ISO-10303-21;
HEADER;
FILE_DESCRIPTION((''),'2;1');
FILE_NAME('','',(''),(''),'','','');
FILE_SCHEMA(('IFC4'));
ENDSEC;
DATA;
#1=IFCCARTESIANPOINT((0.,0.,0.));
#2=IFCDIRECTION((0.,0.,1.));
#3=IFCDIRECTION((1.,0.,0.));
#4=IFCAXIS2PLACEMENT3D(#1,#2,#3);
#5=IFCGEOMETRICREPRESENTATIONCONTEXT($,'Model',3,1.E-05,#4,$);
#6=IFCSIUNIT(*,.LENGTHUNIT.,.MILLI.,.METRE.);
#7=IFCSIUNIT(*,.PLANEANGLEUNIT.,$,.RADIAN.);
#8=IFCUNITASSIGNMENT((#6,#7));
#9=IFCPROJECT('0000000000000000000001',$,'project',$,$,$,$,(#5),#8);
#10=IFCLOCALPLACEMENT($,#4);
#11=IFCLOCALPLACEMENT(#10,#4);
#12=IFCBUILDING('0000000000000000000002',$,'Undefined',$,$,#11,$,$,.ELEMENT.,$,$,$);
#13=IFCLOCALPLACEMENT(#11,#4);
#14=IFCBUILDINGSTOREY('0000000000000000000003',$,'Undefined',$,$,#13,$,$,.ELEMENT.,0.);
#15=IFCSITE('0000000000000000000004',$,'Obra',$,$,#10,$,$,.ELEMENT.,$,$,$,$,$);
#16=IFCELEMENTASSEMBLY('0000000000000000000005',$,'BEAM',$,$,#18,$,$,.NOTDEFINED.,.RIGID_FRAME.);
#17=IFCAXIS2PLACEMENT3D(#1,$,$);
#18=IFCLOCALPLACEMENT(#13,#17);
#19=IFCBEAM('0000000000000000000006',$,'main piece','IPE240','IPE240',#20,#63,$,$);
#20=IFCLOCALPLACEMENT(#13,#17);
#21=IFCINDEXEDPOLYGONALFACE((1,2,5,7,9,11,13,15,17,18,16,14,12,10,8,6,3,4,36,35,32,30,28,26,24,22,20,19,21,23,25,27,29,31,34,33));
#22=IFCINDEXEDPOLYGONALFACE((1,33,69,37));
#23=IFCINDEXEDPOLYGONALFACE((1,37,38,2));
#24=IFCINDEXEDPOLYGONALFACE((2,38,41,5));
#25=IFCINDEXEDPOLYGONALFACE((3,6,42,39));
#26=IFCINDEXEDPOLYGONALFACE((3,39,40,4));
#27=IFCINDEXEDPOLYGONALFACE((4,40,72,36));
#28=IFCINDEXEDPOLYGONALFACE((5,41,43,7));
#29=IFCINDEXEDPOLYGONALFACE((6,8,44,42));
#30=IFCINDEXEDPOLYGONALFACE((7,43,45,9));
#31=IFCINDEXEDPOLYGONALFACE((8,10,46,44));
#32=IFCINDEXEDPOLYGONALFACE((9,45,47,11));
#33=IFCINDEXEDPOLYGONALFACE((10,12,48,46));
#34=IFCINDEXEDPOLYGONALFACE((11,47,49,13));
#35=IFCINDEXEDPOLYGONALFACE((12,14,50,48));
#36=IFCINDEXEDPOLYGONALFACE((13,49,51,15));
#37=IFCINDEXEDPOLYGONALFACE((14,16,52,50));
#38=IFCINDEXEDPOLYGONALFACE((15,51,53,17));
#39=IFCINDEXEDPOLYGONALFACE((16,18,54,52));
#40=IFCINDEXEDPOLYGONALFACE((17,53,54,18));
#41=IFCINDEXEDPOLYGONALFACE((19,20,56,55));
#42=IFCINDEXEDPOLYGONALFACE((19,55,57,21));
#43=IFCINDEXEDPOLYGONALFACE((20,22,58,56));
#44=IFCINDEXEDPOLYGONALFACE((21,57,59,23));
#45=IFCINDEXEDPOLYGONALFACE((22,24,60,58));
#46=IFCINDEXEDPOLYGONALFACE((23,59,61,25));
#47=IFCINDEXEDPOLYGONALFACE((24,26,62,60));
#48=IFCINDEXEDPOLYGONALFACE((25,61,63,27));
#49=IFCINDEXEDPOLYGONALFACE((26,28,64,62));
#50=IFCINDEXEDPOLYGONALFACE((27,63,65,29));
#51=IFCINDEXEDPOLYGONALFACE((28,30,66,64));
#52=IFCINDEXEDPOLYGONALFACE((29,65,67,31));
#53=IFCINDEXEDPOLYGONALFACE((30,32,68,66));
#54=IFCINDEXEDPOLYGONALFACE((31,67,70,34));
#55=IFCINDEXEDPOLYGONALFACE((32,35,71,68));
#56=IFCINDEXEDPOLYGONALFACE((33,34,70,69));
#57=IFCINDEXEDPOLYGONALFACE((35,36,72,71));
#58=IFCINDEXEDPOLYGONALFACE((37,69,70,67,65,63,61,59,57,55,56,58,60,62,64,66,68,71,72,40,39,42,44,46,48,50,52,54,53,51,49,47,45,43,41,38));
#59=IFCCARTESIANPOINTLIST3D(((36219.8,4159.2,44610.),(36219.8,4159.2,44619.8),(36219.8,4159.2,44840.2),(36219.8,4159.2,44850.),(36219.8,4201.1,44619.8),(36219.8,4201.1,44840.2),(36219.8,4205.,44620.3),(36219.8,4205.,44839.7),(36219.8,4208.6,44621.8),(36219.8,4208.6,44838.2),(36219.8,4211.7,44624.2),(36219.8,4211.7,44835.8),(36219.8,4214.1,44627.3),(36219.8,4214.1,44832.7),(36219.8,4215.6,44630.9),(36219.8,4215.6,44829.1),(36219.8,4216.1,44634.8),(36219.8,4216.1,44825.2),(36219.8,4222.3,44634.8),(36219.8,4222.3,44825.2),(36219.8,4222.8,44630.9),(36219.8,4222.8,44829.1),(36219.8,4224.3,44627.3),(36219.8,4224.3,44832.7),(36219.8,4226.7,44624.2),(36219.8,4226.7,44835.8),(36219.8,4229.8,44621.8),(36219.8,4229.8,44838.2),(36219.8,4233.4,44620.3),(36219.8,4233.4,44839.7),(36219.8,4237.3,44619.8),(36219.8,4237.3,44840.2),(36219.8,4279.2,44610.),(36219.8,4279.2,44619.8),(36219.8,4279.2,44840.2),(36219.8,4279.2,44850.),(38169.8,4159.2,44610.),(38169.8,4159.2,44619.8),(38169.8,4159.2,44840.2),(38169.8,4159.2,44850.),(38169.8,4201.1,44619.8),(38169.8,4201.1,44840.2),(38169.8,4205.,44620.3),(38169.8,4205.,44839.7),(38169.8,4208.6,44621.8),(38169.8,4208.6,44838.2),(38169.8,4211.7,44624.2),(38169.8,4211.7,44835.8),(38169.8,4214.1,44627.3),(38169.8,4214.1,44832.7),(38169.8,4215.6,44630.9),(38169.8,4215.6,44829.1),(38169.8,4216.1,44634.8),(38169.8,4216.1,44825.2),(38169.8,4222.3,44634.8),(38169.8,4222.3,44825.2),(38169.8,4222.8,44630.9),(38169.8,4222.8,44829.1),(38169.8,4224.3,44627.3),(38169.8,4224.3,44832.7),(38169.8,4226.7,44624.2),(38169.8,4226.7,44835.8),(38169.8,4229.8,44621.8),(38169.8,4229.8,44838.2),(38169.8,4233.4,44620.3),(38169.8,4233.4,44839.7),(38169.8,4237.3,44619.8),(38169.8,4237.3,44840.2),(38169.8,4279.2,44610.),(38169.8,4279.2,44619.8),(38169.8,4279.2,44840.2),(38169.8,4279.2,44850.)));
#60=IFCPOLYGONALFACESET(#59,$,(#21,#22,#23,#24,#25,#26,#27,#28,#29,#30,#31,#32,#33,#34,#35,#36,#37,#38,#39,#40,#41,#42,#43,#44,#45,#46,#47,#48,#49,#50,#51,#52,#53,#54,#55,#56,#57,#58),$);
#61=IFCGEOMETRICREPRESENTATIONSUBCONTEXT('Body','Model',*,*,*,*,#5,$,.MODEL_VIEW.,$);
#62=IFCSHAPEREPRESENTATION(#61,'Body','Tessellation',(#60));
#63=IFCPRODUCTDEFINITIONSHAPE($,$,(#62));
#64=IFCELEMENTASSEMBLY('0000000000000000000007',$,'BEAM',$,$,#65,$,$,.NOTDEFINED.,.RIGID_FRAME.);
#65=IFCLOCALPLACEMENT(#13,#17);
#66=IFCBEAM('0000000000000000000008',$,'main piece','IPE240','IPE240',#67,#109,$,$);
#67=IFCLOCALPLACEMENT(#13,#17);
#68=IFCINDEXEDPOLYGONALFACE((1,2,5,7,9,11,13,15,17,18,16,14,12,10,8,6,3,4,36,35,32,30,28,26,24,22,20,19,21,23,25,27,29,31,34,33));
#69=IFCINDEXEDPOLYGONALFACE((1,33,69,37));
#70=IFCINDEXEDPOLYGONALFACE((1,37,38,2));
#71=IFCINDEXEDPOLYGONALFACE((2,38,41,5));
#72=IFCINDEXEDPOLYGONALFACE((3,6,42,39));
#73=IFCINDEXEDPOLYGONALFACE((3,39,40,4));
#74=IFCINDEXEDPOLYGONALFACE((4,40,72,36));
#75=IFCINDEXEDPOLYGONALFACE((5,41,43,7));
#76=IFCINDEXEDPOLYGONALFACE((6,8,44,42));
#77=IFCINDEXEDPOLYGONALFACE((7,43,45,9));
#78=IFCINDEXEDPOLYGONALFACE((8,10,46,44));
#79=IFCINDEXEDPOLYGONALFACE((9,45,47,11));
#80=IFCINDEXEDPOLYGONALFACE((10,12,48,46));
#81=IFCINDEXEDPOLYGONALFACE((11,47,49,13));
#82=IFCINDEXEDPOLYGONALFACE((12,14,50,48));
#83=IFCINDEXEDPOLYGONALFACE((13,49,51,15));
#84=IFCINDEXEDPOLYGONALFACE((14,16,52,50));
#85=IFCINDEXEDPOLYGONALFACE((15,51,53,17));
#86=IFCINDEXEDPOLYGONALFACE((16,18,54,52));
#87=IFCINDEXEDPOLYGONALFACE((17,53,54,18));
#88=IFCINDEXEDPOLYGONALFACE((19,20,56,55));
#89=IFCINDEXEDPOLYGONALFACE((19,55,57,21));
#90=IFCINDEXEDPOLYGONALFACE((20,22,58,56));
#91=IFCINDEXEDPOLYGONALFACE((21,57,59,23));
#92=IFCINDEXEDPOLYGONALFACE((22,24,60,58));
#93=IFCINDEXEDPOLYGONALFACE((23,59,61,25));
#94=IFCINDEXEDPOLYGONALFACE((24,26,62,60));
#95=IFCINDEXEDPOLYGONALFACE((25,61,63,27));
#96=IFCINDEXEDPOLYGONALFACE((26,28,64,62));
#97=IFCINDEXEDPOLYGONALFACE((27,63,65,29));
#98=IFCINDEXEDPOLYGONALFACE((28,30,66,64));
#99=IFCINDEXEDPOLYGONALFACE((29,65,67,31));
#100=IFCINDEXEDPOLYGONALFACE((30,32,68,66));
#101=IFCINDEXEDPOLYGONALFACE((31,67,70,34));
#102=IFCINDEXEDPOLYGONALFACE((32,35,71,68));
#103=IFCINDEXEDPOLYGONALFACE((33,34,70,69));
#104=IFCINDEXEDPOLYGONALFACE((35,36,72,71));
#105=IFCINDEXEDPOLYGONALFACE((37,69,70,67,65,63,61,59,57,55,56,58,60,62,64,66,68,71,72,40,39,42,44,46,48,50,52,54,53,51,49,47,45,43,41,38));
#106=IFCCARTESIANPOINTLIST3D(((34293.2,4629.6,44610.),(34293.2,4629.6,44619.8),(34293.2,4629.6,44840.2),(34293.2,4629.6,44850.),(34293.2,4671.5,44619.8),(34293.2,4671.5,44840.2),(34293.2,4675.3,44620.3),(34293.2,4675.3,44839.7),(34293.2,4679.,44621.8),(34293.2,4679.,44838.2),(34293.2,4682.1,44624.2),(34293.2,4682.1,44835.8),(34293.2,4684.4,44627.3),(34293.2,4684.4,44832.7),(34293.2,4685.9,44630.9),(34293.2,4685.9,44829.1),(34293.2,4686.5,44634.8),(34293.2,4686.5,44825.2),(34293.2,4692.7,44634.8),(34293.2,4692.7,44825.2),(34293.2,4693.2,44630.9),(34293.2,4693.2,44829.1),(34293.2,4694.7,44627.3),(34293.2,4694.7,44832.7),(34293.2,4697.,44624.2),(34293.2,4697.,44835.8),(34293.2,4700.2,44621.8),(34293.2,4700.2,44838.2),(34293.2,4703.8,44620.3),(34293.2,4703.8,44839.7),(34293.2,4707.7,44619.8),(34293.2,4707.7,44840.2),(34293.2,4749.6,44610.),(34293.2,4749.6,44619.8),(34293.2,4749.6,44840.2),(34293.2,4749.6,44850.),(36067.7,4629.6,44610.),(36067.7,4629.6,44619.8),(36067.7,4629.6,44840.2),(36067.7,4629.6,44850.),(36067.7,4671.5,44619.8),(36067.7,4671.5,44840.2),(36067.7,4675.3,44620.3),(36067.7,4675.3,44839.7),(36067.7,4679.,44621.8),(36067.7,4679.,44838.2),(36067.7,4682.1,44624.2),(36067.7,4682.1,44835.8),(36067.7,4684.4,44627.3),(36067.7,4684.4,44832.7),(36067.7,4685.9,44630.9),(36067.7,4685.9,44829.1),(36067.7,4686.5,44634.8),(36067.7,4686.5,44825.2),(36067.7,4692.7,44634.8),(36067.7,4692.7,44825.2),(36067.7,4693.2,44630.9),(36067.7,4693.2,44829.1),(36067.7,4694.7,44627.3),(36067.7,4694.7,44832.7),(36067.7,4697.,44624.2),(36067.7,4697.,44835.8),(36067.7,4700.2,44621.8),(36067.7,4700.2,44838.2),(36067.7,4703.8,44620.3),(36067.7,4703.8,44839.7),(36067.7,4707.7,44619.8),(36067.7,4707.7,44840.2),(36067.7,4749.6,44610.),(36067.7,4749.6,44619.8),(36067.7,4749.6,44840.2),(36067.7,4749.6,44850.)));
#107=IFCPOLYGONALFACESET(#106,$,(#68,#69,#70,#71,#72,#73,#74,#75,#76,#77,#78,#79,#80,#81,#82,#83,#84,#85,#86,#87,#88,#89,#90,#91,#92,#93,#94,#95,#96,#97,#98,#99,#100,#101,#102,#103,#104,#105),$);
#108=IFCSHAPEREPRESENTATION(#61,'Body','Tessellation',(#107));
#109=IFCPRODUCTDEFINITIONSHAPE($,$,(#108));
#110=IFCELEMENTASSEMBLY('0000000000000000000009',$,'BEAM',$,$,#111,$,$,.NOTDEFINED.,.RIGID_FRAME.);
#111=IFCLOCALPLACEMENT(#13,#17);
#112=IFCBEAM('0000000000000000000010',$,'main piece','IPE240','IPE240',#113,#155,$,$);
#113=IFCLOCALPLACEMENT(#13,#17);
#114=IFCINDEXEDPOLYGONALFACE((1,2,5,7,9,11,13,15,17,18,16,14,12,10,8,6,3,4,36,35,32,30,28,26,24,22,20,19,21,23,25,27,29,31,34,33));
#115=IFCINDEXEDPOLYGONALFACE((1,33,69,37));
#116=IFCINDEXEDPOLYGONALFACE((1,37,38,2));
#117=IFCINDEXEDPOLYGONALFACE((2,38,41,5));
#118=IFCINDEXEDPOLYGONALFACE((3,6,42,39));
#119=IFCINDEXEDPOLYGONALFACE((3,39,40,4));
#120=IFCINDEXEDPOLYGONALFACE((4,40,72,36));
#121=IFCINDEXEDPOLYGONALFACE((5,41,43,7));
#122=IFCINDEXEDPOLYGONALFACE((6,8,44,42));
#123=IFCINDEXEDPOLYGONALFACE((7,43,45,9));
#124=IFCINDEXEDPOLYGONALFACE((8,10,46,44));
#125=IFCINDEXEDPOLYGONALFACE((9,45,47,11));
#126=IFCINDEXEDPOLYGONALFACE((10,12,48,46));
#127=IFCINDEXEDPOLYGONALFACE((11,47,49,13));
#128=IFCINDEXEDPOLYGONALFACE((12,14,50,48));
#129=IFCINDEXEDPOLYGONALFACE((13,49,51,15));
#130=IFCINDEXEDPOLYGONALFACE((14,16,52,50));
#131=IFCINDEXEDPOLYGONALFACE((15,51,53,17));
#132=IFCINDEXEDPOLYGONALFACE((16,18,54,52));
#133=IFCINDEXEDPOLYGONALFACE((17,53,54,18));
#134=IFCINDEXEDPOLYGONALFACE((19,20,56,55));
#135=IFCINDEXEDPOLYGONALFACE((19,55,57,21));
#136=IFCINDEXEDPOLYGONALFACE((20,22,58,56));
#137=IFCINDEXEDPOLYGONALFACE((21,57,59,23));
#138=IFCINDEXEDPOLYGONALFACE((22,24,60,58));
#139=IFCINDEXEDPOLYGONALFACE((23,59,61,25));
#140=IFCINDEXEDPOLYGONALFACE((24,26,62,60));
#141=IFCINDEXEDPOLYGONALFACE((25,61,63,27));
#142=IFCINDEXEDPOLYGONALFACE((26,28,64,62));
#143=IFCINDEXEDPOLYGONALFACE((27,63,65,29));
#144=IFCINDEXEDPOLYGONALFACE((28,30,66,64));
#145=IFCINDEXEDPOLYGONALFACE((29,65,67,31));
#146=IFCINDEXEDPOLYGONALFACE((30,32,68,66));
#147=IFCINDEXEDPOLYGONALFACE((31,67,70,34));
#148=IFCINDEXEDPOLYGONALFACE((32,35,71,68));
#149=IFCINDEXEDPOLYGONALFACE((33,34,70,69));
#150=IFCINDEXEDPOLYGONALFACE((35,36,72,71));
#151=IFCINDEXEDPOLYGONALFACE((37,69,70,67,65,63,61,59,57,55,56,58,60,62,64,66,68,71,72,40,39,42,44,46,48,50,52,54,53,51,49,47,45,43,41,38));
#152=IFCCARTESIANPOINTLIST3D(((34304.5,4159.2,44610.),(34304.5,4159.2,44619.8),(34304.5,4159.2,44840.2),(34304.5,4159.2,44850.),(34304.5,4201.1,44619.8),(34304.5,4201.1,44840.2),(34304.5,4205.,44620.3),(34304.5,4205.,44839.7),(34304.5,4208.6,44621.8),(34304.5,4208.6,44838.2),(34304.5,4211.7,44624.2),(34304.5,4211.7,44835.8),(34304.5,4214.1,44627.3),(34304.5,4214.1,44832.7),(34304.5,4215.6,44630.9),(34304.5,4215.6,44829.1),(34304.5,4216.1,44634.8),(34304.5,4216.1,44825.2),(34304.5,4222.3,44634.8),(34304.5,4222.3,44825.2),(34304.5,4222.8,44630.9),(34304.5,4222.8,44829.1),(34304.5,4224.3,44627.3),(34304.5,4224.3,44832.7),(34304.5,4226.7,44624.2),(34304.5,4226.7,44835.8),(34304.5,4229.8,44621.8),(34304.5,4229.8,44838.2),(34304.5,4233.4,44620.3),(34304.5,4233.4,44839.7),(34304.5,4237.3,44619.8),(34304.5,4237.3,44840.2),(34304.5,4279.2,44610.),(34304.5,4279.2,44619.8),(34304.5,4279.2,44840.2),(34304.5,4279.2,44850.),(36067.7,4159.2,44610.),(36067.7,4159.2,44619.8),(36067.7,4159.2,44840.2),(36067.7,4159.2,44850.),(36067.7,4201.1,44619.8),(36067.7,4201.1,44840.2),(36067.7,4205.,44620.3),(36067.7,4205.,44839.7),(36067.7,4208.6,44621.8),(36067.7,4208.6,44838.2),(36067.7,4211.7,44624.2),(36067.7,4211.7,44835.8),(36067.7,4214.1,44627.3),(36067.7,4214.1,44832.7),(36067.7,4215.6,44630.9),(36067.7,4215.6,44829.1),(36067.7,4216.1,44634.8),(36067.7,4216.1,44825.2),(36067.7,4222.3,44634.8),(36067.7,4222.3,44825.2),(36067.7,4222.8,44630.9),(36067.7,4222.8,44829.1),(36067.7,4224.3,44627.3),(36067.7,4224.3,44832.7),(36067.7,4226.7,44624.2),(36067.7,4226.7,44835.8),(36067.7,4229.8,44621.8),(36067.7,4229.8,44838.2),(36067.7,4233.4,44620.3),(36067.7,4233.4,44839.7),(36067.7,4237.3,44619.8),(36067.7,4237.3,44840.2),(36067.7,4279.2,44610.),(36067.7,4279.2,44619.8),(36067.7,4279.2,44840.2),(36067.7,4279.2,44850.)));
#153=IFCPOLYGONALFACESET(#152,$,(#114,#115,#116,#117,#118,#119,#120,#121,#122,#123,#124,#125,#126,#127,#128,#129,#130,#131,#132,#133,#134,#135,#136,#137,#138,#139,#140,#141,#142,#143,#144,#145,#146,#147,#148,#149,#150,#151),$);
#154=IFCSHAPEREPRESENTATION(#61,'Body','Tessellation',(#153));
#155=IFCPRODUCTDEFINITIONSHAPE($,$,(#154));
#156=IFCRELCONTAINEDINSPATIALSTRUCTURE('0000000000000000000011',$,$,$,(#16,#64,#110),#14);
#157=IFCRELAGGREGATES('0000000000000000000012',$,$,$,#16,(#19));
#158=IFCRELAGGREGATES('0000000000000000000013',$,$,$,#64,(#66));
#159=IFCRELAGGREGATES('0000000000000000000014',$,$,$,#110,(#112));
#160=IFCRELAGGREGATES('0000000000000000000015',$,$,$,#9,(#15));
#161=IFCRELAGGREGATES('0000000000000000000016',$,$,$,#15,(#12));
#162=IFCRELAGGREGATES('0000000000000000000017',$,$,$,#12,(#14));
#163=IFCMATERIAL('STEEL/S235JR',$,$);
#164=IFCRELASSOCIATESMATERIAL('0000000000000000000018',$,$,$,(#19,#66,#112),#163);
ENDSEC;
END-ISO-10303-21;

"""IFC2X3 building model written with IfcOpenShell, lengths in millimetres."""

from ifc_helpers import new_model, si_unit, frame, origin_with_axes, origin_2d_with_axis, place, context, subcontext, project, spatial, i_section, extrude, material, element, aggregate, save


model = new_model("IFC2X3")

# Units and contexts
model_context = context("Model", 3, precision=1e-05, world=origin_with_axes())
body_context = subcontext(model_context, "Body", "Model", "MODEL_VIEW")
ifc_project = project(units=[si_unit("LENGTHUNIT", "METRE", prefix="MILLI"), si_unit("PLANEANGLEUNIT", "RADIAN")], contexts=[model_context])

# Site, building, storey
site_placement = place(None, origin_with_axes())
site = spatial("IfcSite", under=ifc_project, at=site_placement, Name="Obra", CompositionType="ELEMENT")
building_placement = place(site_placement, origin_with_axes())
building = spatial("IfcBuilding", under=site, at=building_placement, Name="Undefined", CompositionType="ELEMENT")
storey_placement = place(building_placement, origin_with_axes())
storey = spatial("IfcBuildingStorey", under=building, at=storey_placement, Name="Undefined", CompositionType="ELEMENT", Elevation=0.0)

# Shared definitions
ifc_material_1 = material(Name="STEEL/S235JR")

# Element assemblies, beams
assembly_1_placement = place(storey_placement, origin_with_axes())
assembly_1 = element("IfcElementAssembly", 1, at=assembly_1_placement, inside=storey, Name="BEAM", AssemblyPlace="NOTDEFINED", PredefinedType="RIGID_FRAME")
beam_1_placement = place(assembly_1_placement, frame((38169.8, 4219.2, 44730.0), z_axis=(0.0, 0.0, 1.0), x_axis=(-1.0, 0.0, 0.0)))
beam_1 = element("IfcBeam", 2, at=beam_1_placement, material=ifc_material_1, Name="main piece", Description="IPE240", ObjectType="IPE240", context=body_context, shape_type="SweptSolid", body=[
    extrude(i_section(OverallWidth=120.0, OverallDepth=240.0, WebThickness=6.2, FlangeThickness=9.8, FilletRadius=15.0, at=origin_2d_with_axis()), frame((1950.0, 0.0, 0.0), z_axis=(-1.0, 0.0, 0.0), x_axis=(0.0, -1.0, 0.0)), (0.0, 0.0, 1.0), 1950.0),
])
aggregate(assembly_1, [beam_1])
assembly_2_placement = place(storey_placement, origin_with_axes())
assembly_2 = element("IfcElementAssembly", 3, at=assembly_2_placement, inside=storey, Name="BEAM", AssemblyPlace="NOTDEFINED", PredefinedType="RIGID_FRAME")
beam_2_placement = place(assembly_2_placement, frame((34293.2, 4689.6, 44730.0), z_axis=(0.0, 0.0, 1.0), x_axis=(1.0, 0.0, 0.0)))
beam_2 = element("IfcBeam", 4, at=beam_2_placement, material=ifc_material_1, Name="main piece", Description="IPE240", ObjectType="IPE240", context=body_context, shape_type="SweptSolid", body=[
    extrude(i_section(OverallWidth=120.0, OverallDepth=240.0, WebThickness=6.2, FlangeThickness=9.8, FilletRadius=15.0, at=origin_2d_with_axis()), frame((1774.5, 0.0, 0.0), z_axis=(-1.0, 0.0, 0.0), x_axis=(0.0, -1.0, 0.0)), (0.0, 0.0, 1.0), 1774.5),
])
aggregate(assembly_2, [beam_2])
assembly_3_placement = place(storey_placement, origin_with_axes())
assembly_3 = element("IfcElementAssembly", 5, at=assembly_3_placement, inside=storey, Name="BEAM", AssemblyPlace="NOTDEFINED", PredefinedType="RIGID_FRAME")
beam_3_placement = place(assembly_3_placement, frame((34304.5, 4219.2, 44730.0), z_axis=(0.0, 0.0, 1.0), x_axis=(1.0, 0.0, 0.0)))
beam_3 = element("IfcBeam", 6, at=beam_3_placement, material=ifc_material_1, Name="main piece", Description="IPE240", ObjectType="IPE240", context=body_context, shape_type="SweptSolid", body=[
    extrude(i_section(OverallWidth=120.0, OverallDepth=240.0, WebThickness=6.2, FlangeThickness=9.8, FilletRadius=15.0, at=origin_2d_with_axis()), frame((1763.2, 0.0, 0.0), z_axis=(-1.0, 0.0, 0.0), x_axis=(0.0, -1.0, 0.0)), (0.0, 0.0, 1.0), 1763.2),
])
aggregate(assembly_3, [beam_3])

save(model, "model.ifc")
